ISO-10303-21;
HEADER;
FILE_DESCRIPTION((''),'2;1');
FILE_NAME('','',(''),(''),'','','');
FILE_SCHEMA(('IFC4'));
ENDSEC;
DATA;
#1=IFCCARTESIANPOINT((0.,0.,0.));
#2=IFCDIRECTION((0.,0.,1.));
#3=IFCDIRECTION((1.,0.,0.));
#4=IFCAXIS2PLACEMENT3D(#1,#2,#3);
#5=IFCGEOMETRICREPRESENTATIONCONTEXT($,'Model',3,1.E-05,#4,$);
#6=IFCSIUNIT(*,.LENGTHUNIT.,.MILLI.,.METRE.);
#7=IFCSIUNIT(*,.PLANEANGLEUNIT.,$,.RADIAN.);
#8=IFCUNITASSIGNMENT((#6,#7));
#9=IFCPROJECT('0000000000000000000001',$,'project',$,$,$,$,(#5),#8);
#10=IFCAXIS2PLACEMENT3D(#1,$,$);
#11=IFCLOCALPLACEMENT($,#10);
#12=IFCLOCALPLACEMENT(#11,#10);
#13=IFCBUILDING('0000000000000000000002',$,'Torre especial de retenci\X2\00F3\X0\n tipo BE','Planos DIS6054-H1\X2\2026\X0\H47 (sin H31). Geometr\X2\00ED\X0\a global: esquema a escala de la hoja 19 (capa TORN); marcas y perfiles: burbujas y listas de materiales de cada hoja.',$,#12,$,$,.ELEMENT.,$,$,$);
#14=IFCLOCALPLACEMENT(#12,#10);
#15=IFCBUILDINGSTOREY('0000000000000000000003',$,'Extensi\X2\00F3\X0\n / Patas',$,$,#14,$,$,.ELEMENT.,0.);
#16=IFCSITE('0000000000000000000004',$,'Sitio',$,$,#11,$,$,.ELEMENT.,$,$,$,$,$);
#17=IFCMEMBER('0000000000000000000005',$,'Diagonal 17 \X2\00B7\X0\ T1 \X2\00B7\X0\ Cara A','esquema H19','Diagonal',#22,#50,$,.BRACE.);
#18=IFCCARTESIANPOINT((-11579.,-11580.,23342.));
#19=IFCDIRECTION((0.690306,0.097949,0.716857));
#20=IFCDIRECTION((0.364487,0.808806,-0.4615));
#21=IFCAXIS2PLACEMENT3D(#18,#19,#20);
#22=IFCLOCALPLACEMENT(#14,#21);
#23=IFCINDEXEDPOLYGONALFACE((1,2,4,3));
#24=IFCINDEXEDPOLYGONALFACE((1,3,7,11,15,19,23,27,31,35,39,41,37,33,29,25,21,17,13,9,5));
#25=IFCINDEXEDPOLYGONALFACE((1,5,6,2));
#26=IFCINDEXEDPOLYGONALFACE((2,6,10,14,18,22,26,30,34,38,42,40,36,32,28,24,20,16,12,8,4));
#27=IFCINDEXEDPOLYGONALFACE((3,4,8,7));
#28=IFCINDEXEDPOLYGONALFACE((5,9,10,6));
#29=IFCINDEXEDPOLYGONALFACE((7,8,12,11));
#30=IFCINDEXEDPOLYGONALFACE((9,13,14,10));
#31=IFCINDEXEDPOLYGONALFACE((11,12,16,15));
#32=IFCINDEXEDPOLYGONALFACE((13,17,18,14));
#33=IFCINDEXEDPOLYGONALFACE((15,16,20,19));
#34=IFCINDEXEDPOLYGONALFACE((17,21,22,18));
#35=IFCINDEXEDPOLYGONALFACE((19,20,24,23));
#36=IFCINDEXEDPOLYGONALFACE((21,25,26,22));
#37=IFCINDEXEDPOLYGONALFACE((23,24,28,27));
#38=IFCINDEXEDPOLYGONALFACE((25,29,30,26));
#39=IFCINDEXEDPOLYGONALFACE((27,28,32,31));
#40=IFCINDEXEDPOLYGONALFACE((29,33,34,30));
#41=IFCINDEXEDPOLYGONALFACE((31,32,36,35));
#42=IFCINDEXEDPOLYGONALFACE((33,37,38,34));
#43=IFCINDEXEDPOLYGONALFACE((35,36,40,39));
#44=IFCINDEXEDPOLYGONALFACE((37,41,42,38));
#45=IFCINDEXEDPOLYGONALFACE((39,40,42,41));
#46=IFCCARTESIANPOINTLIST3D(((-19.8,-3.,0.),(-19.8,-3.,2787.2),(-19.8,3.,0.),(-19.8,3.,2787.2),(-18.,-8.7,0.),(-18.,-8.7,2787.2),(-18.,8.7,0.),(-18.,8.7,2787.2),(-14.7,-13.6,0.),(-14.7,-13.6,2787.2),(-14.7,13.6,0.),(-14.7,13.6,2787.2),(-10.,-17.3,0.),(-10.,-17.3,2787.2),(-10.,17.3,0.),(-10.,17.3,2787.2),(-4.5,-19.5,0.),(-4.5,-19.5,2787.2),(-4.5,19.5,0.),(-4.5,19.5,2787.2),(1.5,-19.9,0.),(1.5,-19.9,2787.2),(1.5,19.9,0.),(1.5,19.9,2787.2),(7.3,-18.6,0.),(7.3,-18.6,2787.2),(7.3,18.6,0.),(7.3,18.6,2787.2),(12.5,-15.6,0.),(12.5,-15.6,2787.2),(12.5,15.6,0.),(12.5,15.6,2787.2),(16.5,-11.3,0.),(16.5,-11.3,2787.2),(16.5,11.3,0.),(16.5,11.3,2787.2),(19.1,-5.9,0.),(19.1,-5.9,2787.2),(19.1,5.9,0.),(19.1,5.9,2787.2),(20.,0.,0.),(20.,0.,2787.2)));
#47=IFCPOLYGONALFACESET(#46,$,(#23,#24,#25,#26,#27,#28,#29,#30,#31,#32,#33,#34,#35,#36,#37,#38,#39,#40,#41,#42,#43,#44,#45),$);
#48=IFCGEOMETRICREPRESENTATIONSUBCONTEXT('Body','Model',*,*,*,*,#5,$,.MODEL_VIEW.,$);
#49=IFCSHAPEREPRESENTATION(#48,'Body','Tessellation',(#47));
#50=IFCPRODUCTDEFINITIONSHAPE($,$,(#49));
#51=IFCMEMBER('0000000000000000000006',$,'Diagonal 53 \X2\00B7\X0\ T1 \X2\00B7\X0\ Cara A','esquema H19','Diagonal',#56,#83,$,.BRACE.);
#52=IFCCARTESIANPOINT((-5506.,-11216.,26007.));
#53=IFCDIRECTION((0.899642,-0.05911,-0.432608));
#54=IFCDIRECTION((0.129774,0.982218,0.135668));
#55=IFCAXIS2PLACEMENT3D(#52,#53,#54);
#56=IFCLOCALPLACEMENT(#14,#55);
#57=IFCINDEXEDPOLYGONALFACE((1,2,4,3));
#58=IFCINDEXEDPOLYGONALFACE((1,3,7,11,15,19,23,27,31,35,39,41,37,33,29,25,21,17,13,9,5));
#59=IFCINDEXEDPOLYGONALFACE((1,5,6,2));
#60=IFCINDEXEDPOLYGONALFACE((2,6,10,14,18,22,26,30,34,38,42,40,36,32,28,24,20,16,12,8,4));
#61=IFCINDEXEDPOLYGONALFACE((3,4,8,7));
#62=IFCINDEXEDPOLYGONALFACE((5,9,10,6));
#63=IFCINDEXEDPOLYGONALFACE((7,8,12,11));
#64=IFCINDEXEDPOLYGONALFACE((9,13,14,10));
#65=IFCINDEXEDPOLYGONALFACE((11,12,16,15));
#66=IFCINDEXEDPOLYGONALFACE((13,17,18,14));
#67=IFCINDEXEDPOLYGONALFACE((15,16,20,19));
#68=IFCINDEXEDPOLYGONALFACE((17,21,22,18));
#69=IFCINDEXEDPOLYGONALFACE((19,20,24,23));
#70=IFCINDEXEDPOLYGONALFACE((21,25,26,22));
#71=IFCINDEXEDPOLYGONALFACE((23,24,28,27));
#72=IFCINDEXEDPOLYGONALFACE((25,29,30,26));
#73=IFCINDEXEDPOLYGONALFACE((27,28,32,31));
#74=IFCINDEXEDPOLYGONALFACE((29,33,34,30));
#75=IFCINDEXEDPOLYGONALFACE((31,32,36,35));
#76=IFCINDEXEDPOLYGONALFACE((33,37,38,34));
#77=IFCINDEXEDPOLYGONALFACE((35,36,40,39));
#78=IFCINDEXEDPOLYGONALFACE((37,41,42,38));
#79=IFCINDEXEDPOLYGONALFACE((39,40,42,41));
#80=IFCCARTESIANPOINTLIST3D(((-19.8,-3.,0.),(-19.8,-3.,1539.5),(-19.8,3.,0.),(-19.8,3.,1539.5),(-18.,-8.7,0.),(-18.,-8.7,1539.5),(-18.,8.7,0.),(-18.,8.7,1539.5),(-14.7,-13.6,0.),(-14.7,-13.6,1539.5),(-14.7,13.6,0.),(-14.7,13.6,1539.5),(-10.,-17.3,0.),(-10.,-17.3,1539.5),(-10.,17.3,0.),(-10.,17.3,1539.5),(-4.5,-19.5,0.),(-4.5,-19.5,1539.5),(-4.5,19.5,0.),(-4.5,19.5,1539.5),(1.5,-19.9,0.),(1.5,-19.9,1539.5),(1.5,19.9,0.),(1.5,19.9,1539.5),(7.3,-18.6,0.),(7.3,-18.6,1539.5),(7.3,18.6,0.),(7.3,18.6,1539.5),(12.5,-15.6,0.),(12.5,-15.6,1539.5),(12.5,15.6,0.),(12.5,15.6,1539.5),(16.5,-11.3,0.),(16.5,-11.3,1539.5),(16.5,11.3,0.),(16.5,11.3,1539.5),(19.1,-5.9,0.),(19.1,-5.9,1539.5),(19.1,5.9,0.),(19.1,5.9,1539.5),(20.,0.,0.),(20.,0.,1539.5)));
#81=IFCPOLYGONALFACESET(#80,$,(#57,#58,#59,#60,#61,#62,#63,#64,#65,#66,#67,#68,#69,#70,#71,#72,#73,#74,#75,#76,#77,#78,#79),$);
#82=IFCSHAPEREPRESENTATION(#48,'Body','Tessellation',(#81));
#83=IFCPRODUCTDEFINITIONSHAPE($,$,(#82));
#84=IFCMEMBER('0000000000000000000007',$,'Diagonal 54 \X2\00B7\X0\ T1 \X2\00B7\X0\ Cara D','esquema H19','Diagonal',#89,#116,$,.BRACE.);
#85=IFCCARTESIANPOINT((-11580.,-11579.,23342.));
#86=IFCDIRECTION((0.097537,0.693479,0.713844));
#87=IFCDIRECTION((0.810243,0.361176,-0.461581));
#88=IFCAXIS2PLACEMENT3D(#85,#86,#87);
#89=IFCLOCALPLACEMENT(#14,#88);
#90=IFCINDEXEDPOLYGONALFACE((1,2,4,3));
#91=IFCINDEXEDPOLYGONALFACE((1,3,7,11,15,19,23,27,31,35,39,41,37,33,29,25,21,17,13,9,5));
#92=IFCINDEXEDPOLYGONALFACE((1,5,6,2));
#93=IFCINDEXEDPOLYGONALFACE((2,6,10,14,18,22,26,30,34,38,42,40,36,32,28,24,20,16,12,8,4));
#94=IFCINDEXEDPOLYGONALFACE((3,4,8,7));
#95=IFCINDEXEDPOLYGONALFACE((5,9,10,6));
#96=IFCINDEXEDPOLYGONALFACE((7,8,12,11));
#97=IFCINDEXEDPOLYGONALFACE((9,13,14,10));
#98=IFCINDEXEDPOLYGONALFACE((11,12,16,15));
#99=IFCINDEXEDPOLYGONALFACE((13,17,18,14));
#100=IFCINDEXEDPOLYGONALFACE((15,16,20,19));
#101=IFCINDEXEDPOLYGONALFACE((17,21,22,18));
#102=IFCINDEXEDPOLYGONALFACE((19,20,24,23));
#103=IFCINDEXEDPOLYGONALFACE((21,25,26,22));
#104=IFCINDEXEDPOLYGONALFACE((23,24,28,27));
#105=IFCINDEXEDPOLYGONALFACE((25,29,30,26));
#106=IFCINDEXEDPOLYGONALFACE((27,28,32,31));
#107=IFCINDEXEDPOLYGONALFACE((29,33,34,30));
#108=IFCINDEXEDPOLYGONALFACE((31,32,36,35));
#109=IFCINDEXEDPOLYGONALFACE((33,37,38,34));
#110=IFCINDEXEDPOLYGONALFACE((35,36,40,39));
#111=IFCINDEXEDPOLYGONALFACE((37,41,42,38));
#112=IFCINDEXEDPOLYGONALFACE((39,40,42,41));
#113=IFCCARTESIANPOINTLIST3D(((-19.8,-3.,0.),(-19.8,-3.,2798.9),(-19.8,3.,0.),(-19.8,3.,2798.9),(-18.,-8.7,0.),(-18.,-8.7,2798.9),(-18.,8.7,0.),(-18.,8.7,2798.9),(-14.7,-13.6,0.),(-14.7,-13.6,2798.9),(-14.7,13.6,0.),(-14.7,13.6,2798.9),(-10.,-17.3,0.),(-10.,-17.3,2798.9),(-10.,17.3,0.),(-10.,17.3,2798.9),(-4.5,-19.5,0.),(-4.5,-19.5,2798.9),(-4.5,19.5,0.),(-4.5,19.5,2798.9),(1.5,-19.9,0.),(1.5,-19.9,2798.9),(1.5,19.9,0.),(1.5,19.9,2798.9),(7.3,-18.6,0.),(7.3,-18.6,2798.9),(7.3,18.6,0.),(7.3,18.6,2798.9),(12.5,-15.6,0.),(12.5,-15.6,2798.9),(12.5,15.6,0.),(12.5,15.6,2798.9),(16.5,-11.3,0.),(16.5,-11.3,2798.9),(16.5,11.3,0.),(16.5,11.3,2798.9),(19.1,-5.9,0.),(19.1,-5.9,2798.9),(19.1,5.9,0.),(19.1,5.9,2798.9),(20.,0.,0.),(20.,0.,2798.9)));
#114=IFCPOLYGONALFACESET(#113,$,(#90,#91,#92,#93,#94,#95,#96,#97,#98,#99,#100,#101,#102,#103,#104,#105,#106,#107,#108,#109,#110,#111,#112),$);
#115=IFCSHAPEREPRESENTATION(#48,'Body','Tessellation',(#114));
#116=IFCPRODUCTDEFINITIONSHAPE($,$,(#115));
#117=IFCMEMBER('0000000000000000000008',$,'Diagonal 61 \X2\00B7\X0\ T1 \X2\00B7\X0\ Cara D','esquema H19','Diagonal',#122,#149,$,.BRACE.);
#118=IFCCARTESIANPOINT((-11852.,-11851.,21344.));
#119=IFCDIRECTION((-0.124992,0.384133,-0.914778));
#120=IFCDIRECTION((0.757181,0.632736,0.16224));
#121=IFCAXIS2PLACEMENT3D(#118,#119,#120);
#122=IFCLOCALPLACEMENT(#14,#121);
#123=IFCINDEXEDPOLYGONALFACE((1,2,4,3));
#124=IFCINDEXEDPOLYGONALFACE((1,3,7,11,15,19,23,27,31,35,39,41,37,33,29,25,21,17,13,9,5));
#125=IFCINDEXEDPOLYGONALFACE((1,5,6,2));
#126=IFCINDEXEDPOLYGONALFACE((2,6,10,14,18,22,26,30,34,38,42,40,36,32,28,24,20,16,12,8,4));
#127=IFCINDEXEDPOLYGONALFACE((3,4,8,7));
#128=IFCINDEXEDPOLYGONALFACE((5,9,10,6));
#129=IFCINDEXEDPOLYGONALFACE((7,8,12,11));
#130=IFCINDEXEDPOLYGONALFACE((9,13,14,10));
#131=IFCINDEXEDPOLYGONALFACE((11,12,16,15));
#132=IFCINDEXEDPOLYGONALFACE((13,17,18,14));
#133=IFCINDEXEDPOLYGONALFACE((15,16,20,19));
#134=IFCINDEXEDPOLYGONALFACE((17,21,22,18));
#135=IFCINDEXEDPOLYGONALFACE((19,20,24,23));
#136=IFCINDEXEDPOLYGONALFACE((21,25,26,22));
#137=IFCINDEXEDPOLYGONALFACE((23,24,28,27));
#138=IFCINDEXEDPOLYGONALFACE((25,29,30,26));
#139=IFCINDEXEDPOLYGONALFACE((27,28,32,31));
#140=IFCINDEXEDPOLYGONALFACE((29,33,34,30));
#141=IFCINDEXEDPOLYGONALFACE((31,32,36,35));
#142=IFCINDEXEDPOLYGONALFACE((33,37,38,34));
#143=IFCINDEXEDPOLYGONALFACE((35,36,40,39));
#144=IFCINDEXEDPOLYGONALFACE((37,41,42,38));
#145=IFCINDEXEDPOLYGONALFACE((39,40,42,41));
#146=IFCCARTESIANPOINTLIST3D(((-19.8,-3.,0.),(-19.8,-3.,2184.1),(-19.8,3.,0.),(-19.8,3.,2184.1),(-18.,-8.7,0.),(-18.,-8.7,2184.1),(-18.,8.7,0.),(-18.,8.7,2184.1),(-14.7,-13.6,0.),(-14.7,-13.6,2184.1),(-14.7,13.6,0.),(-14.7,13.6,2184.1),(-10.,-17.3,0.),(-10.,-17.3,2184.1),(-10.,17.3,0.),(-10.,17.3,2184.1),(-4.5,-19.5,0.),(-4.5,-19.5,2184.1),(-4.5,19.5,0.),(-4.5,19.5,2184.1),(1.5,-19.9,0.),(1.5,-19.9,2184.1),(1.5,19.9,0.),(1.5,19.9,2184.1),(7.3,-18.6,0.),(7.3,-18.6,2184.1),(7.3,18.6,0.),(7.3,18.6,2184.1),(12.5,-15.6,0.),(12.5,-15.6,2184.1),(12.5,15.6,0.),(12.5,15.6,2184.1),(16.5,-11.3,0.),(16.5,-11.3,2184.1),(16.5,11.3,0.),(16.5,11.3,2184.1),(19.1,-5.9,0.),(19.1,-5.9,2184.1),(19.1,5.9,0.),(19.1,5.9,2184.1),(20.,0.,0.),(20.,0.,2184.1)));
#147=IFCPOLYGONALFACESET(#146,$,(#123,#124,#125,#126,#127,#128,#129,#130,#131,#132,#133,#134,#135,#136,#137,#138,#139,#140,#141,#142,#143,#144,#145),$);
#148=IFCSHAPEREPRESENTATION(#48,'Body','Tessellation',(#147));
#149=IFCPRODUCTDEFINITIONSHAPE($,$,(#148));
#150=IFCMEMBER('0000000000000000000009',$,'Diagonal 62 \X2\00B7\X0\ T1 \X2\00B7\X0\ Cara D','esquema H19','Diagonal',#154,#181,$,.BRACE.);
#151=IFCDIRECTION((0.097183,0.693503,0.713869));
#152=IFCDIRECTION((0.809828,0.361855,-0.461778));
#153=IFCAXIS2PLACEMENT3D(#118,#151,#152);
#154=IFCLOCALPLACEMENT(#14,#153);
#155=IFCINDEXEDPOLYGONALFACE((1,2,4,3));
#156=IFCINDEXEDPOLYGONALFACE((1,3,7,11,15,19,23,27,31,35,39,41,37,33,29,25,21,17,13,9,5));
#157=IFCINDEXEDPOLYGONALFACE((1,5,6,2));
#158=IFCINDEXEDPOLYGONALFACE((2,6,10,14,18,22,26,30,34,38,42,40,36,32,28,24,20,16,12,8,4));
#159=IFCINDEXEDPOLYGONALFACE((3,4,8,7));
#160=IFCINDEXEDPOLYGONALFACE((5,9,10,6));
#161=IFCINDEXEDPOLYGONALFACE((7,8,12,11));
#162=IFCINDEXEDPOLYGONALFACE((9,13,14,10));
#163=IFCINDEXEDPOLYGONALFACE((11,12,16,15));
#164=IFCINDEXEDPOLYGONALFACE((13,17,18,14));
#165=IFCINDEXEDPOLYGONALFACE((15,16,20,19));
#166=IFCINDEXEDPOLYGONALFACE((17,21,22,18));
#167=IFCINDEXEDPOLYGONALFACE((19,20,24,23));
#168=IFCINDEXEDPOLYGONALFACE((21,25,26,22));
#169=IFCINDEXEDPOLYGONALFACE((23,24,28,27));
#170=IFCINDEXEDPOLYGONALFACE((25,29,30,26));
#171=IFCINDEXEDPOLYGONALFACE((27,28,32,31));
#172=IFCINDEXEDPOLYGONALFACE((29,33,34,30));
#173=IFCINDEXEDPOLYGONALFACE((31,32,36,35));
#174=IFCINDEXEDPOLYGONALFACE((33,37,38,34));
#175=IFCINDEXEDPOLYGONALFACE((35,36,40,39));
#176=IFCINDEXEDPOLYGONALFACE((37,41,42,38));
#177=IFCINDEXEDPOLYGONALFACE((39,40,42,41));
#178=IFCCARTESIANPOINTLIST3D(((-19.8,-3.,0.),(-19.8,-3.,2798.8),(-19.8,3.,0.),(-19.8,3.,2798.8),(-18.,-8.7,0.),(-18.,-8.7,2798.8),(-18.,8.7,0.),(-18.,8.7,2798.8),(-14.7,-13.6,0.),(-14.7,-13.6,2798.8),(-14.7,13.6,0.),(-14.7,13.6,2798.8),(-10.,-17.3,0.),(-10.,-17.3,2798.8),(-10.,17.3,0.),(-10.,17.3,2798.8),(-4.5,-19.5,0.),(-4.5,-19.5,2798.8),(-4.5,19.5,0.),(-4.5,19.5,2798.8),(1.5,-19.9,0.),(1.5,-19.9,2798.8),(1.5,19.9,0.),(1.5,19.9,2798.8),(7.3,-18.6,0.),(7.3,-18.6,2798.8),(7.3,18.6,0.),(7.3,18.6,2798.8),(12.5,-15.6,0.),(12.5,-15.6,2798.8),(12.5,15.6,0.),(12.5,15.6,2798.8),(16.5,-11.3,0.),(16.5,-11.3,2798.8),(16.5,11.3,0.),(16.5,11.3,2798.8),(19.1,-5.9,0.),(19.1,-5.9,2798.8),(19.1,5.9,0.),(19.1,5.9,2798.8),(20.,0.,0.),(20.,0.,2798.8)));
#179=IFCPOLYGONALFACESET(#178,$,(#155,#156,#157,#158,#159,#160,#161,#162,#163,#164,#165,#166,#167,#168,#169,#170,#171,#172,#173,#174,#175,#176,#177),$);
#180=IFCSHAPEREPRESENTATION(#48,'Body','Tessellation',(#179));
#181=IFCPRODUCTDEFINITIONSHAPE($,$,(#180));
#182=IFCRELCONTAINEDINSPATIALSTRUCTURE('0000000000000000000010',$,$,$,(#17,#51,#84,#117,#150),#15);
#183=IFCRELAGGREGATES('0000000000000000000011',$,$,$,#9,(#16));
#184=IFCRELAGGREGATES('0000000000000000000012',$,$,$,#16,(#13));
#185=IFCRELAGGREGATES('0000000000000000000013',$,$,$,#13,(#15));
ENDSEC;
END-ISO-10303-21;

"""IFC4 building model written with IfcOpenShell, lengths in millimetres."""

from ifc_helpers import new_model, si_unit, frame, origin, origin_with_axes, place, context, subcontext, project, spatial, circle, extrude, element, save


model = new_model("IFC4")

# Units and contexts
model_context = context("Model", 3, precision=1e-05, world=origin_with_axes())
body_context = subcontext(model_context, "Body", "Model", "MODEL_VIEW")
ifc_project = project(units=[si_unit("LENGTHUNIT", "METRE", prefix="MILLI"), si_unit("PLANEANGLEUNIT", "RADIAN")], contexts=[model_context])

# Site, building, storey
site_placement = place(None, origin())
site = spatial("IfcSite", under=ifc_project, at=site_placement, Name="Sitio", CompositionType="ELEMENT")
building_placement = place(site_placement, origin())
building = spatial("IfcBuilding", under=site, at=building_placement, Name="Torre especial de retención tipo BE", Description="Planos DIS6054-H1…H47 (sin H31). Geometría global: esquema a escala de la hoja 19 (capa TORN); marcas y perfiles: burbujas y listas de materiales de cada hoja.", CompositionType="ELEMENT")
storey_placement = place(building_placement, origin())
storey = spatial("IfcBuildingStorey", under=building, at=storey_placement, Name="Extensión / Patas", CompositionType="ELEMENT", Elevation=0.0)

# Members
member_1_placement = place(storey_placement, frame((-11579.0, -11580.0, 23342.0), z_axis=(0.690306, 0.097949, 0.716857), x_axis=(0.364487, 0.808806, -0.4615)))
element("IfcMember", 1, at=member_1_placement, inside=storey, Name="Diagonal 17 · T1 · Cara A", Description="esquema H19", ObjectType="Diagonal", PredefinedType="BRACE", context=body_context, shape_type="SweptSolid", body=[
    extrude(circle(Radius=20.0), None, (0.0, 0.0, 1.0), 2787.2),
])
member_2_placement = place(storey_placement, frame((-5506.0, -11216.0, 26007.0), z_axis=(0.899642, -0.05911, -0.432608), x_axis=(0.129774, 0.982218, 0.135668)))
element("IfcMember", 2, at=member_2_placement, inside=storey, Name="Diagonal 53 · T1 · Cara A", Description="esquema H19", ObjectType="Diagonal", PredefinedType="BRACE", context=body_context, shape_type="SweptSolid", body=[
    extrude(circle(Radius=20.0), None, (0.0, 0.0, 1.0), 1539.5),
])
member_3_placement = place(storey_placement, frame((-11580.0, -11579.0, 23342.0), z_axis=(0.097537, 0.693479, 0.713844), x_axis=(0.810243, 0.361176, -0.461581)))
element("IfcMember", 3, at=member_3_placement, inside=storey, Name="Diagonal 54 · T1 · Cara D", Description="esquema H19", ObjectType="Diagonal", PredefinedType="BRACE", context=body_context, shape_type="SweptSolid", body=[
    extrude(circle(Radius=20.0), None, (0.0, 0.0, 1.0), 2798.9),
])
member_4_placement = place(storey_placement, frame((-11852.0, -11851.0, 21344.0), z_axis=(-0.124992, 0.384133, -0.914778), x_axis=(0.757181, 0.632736, 0.16224)))
element("IfcMember", 4, at=member_4_placement, inside=storey, Name="Diagonal 61 · T1 · Cara D", Description="esquema H19", ObjectType="Diagonal", PredefinedType="BRACE", context=body_context, shape_type="SweptSolid", body=[
    extrude(circle(Radius=20.0), None, (0.0, 0.0, 1.0), 2184.1),
])
member_5_placement = place(storey_placement, frame((-11852.0, -11851.0, 21344.0), z_axis=(0.097183, 0.693503, 0.713869), x_axis=(0.809828, 0.361855, -0.461778)))
element("IfcMember", 5, at=member_5_placement, inside=storey, Name="Diagonal 62 · T1 · Cara D", Description="esquema H19", ObjectType="Diagonal", PredefinedType="BRACE", context=body_context, shape_type="SweptSolid", body=[
    extrude(circle(Radius=20.0), None, (0.0, 0.0, 1.0), 2798.8),
])

save(model, "model.ifc")
